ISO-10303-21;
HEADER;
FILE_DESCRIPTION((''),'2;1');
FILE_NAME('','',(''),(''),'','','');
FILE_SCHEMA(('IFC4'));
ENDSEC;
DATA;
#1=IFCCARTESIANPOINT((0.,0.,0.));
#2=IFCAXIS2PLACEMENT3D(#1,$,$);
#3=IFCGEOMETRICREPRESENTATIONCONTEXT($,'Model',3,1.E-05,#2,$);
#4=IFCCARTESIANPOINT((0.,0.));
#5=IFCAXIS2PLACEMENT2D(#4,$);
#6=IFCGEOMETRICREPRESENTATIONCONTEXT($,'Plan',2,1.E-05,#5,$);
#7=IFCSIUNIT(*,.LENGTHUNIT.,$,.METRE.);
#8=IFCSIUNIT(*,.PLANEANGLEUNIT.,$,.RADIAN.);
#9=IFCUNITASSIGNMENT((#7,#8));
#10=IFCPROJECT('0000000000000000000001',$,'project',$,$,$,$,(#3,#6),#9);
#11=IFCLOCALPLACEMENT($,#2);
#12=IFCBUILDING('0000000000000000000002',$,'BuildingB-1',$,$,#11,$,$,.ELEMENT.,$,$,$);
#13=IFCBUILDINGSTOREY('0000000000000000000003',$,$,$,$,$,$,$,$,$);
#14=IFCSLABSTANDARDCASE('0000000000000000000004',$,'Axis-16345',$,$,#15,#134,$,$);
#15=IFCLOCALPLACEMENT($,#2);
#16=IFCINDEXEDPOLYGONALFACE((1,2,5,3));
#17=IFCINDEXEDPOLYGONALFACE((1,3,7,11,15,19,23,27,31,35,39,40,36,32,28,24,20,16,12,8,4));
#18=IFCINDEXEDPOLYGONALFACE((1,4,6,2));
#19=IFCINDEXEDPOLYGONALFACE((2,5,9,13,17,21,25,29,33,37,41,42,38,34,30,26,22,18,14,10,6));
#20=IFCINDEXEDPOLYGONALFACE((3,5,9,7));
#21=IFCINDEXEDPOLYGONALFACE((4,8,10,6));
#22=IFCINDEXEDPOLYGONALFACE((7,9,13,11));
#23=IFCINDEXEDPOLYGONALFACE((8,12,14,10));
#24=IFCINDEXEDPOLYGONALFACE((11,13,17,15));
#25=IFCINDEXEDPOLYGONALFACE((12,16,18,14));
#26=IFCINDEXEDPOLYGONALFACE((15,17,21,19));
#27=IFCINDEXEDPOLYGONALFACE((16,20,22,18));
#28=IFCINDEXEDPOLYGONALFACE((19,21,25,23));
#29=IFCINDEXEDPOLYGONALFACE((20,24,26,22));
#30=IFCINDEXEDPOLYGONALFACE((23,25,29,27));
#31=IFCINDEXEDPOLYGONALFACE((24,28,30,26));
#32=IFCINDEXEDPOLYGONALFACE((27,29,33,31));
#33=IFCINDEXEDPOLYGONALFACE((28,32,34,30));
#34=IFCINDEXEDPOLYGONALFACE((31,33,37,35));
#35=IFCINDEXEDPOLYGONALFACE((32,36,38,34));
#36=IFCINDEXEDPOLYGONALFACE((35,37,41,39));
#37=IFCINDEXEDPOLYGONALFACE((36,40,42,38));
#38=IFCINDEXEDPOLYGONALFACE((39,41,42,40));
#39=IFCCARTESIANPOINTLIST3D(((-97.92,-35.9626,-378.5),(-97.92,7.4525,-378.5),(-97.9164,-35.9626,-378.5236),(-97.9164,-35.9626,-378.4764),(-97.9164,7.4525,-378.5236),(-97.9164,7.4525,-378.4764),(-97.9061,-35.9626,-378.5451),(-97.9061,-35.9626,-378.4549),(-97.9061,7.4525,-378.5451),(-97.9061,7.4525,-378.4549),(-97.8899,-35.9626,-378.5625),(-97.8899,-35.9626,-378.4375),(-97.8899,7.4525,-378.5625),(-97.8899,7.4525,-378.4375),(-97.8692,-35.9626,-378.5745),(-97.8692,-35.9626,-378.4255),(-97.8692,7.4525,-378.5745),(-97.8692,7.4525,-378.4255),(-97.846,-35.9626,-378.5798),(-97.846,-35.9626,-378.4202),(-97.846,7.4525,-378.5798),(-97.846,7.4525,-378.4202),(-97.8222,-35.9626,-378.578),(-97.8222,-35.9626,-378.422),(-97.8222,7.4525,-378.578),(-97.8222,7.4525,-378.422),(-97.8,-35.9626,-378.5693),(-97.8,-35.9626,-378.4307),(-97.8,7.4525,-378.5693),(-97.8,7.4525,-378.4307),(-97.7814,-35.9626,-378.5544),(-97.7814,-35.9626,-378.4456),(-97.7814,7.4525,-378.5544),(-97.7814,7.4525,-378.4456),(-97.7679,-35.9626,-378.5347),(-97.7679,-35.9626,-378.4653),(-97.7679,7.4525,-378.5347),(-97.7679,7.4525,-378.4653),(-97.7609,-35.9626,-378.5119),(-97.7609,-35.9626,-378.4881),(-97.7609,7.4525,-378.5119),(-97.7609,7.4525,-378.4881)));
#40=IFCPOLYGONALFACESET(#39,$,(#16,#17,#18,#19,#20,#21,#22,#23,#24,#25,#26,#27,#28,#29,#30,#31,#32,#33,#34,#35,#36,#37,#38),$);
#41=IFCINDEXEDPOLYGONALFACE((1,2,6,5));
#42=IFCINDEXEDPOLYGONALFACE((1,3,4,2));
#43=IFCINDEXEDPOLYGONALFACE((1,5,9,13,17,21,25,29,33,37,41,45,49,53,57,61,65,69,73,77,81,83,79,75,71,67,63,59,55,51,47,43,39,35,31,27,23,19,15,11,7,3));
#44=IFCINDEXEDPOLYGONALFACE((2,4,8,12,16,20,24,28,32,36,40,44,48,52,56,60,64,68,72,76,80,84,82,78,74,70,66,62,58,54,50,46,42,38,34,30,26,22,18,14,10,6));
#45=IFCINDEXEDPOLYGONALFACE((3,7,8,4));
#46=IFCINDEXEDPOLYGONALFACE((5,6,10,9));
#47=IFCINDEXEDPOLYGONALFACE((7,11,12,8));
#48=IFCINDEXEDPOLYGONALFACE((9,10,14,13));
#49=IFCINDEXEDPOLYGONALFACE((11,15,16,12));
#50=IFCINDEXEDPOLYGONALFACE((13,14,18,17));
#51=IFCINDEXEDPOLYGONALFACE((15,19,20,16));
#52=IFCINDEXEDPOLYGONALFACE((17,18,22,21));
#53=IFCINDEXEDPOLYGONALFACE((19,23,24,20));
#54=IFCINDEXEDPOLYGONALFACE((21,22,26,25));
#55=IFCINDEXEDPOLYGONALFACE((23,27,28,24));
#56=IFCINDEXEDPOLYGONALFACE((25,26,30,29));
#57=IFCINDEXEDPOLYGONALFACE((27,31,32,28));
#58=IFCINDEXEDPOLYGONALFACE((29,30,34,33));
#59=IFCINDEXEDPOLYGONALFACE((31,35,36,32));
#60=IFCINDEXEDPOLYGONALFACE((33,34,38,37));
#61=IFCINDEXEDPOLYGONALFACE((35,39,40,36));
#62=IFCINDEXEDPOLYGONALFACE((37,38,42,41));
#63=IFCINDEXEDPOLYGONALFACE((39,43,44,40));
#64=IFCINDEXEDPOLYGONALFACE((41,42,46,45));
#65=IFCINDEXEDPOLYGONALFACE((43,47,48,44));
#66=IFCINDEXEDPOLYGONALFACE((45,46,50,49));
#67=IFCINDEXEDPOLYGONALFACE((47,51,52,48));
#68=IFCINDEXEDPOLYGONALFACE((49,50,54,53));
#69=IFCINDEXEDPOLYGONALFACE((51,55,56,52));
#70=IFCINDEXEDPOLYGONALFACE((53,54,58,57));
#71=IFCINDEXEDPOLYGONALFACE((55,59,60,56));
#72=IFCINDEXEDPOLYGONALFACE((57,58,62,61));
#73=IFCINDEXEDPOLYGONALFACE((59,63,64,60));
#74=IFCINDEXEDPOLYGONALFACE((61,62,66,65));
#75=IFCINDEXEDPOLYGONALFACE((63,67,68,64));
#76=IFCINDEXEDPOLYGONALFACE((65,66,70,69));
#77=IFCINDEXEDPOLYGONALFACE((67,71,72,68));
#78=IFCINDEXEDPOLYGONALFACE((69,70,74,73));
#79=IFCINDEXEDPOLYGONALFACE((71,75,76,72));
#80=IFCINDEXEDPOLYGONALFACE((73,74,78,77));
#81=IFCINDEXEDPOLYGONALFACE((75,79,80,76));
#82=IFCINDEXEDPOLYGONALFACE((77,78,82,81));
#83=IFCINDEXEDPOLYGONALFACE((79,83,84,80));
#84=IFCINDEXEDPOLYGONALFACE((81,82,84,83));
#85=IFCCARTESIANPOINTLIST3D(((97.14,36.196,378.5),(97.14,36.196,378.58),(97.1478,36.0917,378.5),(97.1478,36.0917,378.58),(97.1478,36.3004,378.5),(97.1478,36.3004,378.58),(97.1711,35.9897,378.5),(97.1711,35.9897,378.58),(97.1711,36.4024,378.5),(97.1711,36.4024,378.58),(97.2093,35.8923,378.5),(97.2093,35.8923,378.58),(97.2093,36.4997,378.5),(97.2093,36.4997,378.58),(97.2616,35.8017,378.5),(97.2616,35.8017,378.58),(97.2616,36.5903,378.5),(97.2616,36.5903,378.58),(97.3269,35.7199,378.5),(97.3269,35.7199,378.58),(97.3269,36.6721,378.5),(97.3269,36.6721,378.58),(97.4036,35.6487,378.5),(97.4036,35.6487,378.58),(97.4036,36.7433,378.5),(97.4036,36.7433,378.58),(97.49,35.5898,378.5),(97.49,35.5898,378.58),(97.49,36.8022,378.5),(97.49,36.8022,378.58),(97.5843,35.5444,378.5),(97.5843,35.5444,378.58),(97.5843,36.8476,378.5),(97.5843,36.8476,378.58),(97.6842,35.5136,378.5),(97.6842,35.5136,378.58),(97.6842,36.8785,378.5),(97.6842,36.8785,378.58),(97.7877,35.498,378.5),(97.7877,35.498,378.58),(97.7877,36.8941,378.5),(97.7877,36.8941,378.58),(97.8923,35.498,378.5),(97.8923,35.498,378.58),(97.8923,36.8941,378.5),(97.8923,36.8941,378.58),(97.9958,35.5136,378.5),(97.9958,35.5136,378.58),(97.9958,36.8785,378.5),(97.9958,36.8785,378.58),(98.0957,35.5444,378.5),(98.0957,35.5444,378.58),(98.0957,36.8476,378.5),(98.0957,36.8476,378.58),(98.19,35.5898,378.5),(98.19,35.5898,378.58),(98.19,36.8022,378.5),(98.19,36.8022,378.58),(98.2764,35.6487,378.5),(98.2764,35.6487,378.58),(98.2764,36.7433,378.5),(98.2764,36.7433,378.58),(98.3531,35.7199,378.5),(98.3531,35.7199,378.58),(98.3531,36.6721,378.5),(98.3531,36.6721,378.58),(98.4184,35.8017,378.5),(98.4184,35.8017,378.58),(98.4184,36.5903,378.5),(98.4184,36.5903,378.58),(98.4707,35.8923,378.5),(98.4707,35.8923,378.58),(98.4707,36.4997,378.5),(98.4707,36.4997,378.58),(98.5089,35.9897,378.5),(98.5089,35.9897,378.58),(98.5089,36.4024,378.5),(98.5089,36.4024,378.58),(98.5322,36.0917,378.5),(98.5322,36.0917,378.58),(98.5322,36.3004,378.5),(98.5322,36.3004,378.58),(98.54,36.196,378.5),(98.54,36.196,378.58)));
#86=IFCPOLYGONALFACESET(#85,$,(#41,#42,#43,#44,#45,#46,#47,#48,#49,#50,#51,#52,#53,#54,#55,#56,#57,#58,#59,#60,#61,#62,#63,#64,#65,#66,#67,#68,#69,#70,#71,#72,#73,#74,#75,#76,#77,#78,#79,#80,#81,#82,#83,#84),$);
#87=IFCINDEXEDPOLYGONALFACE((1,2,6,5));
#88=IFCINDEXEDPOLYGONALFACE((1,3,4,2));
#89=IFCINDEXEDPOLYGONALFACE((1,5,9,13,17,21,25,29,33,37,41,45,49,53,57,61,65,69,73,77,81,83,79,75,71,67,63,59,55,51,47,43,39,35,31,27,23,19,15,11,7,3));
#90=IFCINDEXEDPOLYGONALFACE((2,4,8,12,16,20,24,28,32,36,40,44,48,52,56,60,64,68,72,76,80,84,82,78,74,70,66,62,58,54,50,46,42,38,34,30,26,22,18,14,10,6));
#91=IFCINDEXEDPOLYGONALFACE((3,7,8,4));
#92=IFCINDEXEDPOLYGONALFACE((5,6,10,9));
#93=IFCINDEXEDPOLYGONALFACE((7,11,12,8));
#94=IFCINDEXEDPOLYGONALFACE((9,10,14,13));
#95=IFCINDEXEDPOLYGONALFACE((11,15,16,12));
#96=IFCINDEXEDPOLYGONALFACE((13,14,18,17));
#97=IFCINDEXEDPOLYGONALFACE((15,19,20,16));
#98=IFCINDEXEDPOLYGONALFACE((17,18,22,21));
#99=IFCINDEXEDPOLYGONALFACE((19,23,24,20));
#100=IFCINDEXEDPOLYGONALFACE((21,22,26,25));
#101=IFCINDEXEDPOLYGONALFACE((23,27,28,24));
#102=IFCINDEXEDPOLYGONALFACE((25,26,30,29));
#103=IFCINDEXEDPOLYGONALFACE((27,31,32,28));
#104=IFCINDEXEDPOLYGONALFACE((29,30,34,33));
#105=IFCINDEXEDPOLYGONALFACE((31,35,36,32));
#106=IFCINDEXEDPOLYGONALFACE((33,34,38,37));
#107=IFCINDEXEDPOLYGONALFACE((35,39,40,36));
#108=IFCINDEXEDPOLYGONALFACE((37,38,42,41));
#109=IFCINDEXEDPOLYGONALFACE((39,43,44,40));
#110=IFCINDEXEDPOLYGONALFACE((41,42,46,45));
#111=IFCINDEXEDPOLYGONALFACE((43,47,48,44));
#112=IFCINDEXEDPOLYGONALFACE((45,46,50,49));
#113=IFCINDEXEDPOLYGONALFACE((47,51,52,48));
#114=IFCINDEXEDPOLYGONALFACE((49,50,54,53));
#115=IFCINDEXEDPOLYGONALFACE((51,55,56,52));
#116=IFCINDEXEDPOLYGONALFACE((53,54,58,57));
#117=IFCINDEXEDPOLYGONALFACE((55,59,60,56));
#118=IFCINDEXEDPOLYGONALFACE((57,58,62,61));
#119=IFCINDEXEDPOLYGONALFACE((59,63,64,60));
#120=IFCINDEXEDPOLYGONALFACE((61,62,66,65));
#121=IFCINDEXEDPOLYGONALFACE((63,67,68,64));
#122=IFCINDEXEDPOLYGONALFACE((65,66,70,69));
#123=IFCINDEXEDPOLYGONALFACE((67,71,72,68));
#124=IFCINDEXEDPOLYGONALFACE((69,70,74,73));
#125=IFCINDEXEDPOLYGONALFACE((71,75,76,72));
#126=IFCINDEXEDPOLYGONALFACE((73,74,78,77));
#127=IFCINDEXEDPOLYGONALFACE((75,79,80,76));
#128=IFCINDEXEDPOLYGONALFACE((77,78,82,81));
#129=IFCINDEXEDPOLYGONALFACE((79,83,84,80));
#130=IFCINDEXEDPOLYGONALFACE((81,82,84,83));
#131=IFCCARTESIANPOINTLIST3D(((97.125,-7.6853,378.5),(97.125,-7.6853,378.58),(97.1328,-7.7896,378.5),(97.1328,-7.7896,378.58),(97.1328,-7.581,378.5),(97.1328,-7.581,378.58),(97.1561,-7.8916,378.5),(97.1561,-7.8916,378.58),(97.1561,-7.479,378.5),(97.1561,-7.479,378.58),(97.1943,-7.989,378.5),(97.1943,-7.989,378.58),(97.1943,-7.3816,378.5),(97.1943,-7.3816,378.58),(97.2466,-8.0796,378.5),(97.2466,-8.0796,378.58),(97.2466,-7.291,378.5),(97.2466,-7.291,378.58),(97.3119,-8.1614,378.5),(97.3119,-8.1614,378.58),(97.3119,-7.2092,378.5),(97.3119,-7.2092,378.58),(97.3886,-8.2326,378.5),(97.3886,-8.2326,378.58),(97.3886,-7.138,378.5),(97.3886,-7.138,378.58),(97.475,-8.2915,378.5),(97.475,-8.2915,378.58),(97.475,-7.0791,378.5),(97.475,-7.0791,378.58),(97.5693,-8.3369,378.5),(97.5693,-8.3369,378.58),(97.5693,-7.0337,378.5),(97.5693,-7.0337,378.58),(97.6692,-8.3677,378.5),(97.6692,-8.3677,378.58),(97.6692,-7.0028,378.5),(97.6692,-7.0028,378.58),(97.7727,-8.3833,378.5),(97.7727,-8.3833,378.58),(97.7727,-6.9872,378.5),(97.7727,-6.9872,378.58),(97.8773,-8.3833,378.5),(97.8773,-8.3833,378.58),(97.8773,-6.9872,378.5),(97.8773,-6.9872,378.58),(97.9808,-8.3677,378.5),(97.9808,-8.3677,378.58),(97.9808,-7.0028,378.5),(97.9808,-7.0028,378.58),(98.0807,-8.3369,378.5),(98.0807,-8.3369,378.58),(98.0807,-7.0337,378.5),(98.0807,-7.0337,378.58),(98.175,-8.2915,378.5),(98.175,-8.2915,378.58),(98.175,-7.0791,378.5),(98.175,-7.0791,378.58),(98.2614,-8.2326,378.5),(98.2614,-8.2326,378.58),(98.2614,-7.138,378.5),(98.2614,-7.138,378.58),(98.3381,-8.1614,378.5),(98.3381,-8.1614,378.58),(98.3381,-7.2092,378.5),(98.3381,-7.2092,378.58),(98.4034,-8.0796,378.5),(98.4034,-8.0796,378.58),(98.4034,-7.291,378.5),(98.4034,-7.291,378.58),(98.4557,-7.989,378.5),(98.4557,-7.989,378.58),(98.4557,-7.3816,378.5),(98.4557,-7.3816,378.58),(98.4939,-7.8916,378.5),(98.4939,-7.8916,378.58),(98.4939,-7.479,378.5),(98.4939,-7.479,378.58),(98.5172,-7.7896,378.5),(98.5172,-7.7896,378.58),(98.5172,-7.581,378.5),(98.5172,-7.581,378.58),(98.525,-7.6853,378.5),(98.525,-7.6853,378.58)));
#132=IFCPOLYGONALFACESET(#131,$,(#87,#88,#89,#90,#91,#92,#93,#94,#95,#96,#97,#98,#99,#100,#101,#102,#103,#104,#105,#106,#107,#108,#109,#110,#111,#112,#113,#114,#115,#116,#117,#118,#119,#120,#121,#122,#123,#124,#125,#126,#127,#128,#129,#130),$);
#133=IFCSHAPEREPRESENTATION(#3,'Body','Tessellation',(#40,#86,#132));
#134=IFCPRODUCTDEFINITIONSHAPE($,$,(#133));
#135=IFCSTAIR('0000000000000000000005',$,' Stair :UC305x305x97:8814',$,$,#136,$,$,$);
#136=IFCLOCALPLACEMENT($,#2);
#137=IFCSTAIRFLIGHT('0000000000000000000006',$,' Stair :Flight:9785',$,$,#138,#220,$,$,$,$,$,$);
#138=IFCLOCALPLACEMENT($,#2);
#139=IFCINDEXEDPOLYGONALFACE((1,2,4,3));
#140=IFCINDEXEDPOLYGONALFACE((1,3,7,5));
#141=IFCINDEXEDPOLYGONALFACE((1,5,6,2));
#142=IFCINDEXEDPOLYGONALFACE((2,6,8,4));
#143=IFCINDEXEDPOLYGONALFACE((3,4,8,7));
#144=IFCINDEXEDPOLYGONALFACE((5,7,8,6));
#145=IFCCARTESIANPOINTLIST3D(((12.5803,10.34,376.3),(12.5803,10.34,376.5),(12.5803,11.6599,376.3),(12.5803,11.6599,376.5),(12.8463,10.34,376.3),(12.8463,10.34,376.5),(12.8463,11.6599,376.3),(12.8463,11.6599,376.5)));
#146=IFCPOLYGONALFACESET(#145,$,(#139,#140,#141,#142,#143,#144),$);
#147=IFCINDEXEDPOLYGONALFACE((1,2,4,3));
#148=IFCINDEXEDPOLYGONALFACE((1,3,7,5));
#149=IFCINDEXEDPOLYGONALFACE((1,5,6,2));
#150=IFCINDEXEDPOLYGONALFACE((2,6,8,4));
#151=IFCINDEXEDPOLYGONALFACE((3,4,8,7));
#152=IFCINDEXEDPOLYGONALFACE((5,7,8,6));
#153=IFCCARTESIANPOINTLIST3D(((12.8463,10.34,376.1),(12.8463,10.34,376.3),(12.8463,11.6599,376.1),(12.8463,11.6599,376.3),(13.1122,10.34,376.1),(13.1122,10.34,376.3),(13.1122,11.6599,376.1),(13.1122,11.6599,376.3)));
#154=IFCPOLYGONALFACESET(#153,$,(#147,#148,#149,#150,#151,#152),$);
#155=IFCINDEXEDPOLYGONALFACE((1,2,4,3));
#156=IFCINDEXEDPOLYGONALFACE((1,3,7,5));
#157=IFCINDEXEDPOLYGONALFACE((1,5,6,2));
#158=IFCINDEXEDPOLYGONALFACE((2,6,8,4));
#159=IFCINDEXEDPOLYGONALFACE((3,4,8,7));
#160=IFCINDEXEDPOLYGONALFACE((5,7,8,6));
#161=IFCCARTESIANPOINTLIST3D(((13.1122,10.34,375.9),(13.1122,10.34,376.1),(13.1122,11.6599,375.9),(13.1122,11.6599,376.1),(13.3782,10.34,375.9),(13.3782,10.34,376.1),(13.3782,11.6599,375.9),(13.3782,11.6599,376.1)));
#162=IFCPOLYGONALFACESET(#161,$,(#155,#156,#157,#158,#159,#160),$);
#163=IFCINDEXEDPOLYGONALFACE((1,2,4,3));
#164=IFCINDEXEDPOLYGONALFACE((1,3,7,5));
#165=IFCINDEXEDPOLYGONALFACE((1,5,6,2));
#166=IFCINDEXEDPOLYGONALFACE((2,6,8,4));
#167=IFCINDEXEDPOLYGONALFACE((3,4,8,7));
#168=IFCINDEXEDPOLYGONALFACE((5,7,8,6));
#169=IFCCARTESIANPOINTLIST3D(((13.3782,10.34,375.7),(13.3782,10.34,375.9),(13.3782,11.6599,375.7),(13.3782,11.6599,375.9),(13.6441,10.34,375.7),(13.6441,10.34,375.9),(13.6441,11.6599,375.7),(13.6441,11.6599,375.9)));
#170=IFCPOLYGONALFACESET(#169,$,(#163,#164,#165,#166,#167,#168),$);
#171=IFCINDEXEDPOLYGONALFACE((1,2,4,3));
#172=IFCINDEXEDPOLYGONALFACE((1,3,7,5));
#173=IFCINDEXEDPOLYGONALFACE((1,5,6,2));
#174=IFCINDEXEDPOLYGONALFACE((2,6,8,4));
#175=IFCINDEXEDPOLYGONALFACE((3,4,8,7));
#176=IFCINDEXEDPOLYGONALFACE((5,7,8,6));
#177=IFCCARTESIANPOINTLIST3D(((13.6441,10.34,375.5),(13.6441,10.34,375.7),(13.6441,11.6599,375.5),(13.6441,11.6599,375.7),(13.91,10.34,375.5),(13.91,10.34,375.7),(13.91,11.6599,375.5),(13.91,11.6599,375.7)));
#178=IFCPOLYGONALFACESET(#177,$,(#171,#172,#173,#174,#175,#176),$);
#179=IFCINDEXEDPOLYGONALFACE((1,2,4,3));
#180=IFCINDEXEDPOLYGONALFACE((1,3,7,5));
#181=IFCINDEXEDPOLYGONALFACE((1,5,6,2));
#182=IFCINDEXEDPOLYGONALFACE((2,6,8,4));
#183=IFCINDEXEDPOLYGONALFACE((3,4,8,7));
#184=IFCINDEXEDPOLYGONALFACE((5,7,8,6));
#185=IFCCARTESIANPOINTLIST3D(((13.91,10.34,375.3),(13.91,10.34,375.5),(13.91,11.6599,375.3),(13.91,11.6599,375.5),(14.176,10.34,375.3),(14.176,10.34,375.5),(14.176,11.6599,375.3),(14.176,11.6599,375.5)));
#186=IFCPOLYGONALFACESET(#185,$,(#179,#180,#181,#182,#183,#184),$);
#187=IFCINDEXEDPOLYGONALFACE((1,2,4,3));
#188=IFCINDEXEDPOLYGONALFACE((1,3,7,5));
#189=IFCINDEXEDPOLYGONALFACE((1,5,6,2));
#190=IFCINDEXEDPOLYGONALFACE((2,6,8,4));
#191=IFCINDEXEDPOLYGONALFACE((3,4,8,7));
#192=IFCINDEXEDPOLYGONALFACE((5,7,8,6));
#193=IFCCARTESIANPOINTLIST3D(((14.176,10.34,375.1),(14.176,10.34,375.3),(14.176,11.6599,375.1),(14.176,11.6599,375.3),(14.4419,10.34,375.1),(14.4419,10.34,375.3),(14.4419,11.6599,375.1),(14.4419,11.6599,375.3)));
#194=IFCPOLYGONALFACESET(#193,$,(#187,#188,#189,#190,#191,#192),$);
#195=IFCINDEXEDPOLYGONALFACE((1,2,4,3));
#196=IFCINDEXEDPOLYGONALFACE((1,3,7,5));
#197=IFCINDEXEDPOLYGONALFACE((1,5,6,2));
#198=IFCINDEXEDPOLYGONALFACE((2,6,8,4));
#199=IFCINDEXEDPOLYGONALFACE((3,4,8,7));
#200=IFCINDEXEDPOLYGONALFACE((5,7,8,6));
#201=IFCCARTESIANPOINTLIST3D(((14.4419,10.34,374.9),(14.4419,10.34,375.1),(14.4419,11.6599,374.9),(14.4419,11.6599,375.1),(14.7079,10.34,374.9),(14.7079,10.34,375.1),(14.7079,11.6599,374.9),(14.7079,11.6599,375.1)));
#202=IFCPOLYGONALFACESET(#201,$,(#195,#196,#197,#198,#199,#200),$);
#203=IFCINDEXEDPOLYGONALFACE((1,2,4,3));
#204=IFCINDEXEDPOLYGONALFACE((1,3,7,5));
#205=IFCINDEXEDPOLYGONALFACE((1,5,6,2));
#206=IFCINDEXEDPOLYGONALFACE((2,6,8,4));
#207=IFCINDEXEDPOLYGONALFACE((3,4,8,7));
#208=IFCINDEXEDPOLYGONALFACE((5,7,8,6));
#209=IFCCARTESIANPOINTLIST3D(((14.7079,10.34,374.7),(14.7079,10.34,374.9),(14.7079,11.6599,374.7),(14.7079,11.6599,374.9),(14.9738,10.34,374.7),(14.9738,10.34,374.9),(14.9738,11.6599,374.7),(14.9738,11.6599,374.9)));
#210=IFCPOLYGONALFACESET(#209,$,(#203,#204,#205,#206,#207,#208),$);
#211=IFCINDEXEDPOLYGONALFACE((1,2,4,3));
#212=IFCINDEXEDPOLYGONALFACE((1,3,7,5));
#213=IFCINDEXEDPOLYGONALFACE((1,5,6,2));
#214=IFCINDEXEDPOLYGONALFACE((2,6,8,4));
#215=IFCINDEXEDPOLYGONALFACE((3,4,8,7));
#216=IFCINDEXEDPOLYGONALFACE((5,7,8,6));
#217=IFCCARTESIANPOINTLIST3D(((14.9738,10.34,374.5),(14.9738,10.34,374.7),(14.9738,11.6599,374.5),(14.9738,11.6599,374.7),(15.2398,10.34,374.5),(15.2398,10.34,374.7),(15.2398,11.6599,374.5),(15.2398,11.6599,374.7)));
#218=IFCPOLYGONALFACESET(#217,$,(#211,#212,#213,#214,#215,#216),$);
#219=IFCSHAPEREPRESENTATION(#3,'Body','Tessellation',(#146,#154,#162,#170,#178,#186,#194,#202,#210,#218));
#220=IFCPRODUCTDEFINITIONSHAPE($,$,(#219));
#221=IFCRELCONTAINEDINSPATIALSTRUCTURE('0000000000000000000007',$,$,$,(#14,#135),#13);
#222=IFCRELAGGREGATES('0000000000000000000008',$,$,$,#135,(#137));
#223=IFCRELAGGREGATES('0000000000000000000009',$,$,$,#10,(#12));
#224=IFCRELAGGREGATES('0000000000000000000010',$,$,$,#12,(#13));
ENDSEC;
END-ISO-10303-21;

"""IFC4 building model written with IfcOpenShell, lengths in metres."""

from ifc_helpers import new_model, entity, si_unit, frame, origin, origin_2d, place, context, project, spatial, polyline, circle, outline, extrude, element, aggregate, save


model = new_model("IFC4")

# Units and contexts
model_context = context("Model", 3, precision=1e-05, world=origin())
plan_context = context("Plan", 2, precision=1e-05, world=origin_2d())
ifc_project = project(units=[si_unit("LENGTHUNIT", "METRE"), si_unit("PLANEANGLEUNIT", "RADIAN")], contexts=[model_context, plan_context])

# Building, storey
building_placement = place(None, origin())
building = spatial("IfcBuilding", under=ifc_project, at=building_placement, Name="BuildingB-1", CompositionType="ELEMENT")
storey = spatial("IfcBuildingStorey", under=building)

# Slab
element("IfcSlabStandardCase", 1, inside=storey, Name="Axis-16345", context=model_context, shape_type="AdvancedSweptSolid", body=[
    entity("IfcSurfaceCurveSweptAreaSolid", entity("IfcCircleProfileDef", "AREA", None, None, 0.08), None, entity("IfcPolyline", [entity("IfcCartesianPoint", [97.84, 35.9626, 378.5]), entity("IfcCartesianPoint", [97.84, -7.4525, 378.5])]), None, None, entity("IfcPlane", entity("IfcAxis2Placement3D", entity("IfcCartesianPoint", [97.84, 35.9626, 378.5]), entity("IfcDirection", [0.0, 0.0, 1.0]), entity("IfcDirection", [1.0, 0.0, 0.0])))),
    extrude(circle(Radius=0.7), frame((97.84, 36.196, 378.5)), (0.0, 0.0, 1.0), 0.08),
    extrude(circle(Radius=0.7), frame((97.825, -7.6853, 378.5)), (0.0, 0.0, 1.0), 0.08),
])

# Stair, stair flight
stair_1 = element("IfcStair", 2, inside=storey, Name=" Stair :UC305x305x97:8814")
stair_flight_1 = element("IfcStairFlight", 3, Name=" Stair :Flight:9785", context=model_context, shape_type="SweptSolid", body=[
    extrude(outline(polyline([(12.8463, 11.6599, 376.5), (12.8463, 10.34, 376.5), (12.5803, 10.34, 376.5), (12.5803, 11.6599, 376.5), (12.8463, 11.6599, 376.5)])), origin(), (0.0, 0.0, -1.0), 0.2),
    extrude(outline(polyline([(13.1122, 11.6599, 376.5), (13.1122, 10.34, 376.5), (12.8463, 10.34, 376.5), (12.8463, 11.6599, 376.5), (13.1122, 11.6599, 376.5)])), frame((0.0, 0.0, -0.2)), (0.0, 0.0, -1.0), 0.2),
    extrude(outline(polyline([(13.3782, 11.6599, 376.5), (13.3782, 10.34, 376.5), (13.1122, 10.34, 376.5), (13.1122, 11.6599, 376.5), (13.3782, 11.6599, 376.5)])), frame((0.0, 0.0, -0.4)), (0.0, 0.0, -1.0), 0.2),
    extrude(outline(polyline([(13.6441, 11.6599, 376.5), (13.6441, 10.34, 376.5), (13.3782, 10.34, 376.5), (13.3782, 11.6599, 376.5), (13.6441, 11.6599, 376.5)])), frame((0.0, 0.0, -0.6)), (0.0, 0.0, -1.0), 0.2),
    extrude(outline(polyline([(13.91, 11.6599, 376.5), (13.91, 10.34, 376.5), (13.6441, 10.34, 376.5), (13.6441, 11.6599, 376.5), (13.91, 11.6599, 376.5)])), frame((0.0, 0.0, -0.8)), (0.0, 0.0, -1.0), 0.2),
    extrude(outline(polyline([(14.176, 11.6599, 376.5), (14.176, 10.34, 376.5), (13.91, 10.34, 376.5), (13.91, 11.6599, 376.5), (14.176, 11.6599, 376.5)])), frame((0.0, 0.0, -1.0)), (0.0, 0.0, -1.0), 0.2),
    extrude(outline(polyline([(14.4419, 11.6599, 376.5), (14.4419, 10.34, 376.5), (14.176, 10.34, 376.5), (14.176, 11.6599, 376.5), (14.4419, 11.6599, 376.5)])), frame((0.0, 0.0, -1.2)), (0.0, 0.0, -1.0), 0.2),
    extrude(outline(polyline([(14.7079, 11.6599, 376.5), (14.7079, 10.34, 376.5), (14.4419, 10.34, 376.5), (14.4419, 11.6599, 376.5), (14.7079, 11.6599, 376.5)])), frame((0.0, 0.0, -1.4)), (0.0, 0.0, -1.0), 0.2),
    extrude(outline(polyline([(14.9738, 11.6599, 376.5), (14.9738, 10.34, 376.5), (14.7079, 10.34, 376.5), (14.7079, 11.6599, 376.5), (14.9738, 11.6599, 376.5)])), frame((0.0, 0.0, -1.6)), (0.0, 0.0, -1.0), 0.2),
    extrude(outline(polyline([(15.2398, 11.6599, 376.5), (15.2398, 10.34, 376.5), (14.9738, 10.34, 376.5), (14.9738, 11.6599, 376.5), (15.2398, 11.6599, 376.5)])), frame((0.0, 0.0, -1.8)), (0.0, 0.0, -1.0), 0.2),
])
aggregate(stair_1, [stair_flight_1])

save(model, "model.ifc")
